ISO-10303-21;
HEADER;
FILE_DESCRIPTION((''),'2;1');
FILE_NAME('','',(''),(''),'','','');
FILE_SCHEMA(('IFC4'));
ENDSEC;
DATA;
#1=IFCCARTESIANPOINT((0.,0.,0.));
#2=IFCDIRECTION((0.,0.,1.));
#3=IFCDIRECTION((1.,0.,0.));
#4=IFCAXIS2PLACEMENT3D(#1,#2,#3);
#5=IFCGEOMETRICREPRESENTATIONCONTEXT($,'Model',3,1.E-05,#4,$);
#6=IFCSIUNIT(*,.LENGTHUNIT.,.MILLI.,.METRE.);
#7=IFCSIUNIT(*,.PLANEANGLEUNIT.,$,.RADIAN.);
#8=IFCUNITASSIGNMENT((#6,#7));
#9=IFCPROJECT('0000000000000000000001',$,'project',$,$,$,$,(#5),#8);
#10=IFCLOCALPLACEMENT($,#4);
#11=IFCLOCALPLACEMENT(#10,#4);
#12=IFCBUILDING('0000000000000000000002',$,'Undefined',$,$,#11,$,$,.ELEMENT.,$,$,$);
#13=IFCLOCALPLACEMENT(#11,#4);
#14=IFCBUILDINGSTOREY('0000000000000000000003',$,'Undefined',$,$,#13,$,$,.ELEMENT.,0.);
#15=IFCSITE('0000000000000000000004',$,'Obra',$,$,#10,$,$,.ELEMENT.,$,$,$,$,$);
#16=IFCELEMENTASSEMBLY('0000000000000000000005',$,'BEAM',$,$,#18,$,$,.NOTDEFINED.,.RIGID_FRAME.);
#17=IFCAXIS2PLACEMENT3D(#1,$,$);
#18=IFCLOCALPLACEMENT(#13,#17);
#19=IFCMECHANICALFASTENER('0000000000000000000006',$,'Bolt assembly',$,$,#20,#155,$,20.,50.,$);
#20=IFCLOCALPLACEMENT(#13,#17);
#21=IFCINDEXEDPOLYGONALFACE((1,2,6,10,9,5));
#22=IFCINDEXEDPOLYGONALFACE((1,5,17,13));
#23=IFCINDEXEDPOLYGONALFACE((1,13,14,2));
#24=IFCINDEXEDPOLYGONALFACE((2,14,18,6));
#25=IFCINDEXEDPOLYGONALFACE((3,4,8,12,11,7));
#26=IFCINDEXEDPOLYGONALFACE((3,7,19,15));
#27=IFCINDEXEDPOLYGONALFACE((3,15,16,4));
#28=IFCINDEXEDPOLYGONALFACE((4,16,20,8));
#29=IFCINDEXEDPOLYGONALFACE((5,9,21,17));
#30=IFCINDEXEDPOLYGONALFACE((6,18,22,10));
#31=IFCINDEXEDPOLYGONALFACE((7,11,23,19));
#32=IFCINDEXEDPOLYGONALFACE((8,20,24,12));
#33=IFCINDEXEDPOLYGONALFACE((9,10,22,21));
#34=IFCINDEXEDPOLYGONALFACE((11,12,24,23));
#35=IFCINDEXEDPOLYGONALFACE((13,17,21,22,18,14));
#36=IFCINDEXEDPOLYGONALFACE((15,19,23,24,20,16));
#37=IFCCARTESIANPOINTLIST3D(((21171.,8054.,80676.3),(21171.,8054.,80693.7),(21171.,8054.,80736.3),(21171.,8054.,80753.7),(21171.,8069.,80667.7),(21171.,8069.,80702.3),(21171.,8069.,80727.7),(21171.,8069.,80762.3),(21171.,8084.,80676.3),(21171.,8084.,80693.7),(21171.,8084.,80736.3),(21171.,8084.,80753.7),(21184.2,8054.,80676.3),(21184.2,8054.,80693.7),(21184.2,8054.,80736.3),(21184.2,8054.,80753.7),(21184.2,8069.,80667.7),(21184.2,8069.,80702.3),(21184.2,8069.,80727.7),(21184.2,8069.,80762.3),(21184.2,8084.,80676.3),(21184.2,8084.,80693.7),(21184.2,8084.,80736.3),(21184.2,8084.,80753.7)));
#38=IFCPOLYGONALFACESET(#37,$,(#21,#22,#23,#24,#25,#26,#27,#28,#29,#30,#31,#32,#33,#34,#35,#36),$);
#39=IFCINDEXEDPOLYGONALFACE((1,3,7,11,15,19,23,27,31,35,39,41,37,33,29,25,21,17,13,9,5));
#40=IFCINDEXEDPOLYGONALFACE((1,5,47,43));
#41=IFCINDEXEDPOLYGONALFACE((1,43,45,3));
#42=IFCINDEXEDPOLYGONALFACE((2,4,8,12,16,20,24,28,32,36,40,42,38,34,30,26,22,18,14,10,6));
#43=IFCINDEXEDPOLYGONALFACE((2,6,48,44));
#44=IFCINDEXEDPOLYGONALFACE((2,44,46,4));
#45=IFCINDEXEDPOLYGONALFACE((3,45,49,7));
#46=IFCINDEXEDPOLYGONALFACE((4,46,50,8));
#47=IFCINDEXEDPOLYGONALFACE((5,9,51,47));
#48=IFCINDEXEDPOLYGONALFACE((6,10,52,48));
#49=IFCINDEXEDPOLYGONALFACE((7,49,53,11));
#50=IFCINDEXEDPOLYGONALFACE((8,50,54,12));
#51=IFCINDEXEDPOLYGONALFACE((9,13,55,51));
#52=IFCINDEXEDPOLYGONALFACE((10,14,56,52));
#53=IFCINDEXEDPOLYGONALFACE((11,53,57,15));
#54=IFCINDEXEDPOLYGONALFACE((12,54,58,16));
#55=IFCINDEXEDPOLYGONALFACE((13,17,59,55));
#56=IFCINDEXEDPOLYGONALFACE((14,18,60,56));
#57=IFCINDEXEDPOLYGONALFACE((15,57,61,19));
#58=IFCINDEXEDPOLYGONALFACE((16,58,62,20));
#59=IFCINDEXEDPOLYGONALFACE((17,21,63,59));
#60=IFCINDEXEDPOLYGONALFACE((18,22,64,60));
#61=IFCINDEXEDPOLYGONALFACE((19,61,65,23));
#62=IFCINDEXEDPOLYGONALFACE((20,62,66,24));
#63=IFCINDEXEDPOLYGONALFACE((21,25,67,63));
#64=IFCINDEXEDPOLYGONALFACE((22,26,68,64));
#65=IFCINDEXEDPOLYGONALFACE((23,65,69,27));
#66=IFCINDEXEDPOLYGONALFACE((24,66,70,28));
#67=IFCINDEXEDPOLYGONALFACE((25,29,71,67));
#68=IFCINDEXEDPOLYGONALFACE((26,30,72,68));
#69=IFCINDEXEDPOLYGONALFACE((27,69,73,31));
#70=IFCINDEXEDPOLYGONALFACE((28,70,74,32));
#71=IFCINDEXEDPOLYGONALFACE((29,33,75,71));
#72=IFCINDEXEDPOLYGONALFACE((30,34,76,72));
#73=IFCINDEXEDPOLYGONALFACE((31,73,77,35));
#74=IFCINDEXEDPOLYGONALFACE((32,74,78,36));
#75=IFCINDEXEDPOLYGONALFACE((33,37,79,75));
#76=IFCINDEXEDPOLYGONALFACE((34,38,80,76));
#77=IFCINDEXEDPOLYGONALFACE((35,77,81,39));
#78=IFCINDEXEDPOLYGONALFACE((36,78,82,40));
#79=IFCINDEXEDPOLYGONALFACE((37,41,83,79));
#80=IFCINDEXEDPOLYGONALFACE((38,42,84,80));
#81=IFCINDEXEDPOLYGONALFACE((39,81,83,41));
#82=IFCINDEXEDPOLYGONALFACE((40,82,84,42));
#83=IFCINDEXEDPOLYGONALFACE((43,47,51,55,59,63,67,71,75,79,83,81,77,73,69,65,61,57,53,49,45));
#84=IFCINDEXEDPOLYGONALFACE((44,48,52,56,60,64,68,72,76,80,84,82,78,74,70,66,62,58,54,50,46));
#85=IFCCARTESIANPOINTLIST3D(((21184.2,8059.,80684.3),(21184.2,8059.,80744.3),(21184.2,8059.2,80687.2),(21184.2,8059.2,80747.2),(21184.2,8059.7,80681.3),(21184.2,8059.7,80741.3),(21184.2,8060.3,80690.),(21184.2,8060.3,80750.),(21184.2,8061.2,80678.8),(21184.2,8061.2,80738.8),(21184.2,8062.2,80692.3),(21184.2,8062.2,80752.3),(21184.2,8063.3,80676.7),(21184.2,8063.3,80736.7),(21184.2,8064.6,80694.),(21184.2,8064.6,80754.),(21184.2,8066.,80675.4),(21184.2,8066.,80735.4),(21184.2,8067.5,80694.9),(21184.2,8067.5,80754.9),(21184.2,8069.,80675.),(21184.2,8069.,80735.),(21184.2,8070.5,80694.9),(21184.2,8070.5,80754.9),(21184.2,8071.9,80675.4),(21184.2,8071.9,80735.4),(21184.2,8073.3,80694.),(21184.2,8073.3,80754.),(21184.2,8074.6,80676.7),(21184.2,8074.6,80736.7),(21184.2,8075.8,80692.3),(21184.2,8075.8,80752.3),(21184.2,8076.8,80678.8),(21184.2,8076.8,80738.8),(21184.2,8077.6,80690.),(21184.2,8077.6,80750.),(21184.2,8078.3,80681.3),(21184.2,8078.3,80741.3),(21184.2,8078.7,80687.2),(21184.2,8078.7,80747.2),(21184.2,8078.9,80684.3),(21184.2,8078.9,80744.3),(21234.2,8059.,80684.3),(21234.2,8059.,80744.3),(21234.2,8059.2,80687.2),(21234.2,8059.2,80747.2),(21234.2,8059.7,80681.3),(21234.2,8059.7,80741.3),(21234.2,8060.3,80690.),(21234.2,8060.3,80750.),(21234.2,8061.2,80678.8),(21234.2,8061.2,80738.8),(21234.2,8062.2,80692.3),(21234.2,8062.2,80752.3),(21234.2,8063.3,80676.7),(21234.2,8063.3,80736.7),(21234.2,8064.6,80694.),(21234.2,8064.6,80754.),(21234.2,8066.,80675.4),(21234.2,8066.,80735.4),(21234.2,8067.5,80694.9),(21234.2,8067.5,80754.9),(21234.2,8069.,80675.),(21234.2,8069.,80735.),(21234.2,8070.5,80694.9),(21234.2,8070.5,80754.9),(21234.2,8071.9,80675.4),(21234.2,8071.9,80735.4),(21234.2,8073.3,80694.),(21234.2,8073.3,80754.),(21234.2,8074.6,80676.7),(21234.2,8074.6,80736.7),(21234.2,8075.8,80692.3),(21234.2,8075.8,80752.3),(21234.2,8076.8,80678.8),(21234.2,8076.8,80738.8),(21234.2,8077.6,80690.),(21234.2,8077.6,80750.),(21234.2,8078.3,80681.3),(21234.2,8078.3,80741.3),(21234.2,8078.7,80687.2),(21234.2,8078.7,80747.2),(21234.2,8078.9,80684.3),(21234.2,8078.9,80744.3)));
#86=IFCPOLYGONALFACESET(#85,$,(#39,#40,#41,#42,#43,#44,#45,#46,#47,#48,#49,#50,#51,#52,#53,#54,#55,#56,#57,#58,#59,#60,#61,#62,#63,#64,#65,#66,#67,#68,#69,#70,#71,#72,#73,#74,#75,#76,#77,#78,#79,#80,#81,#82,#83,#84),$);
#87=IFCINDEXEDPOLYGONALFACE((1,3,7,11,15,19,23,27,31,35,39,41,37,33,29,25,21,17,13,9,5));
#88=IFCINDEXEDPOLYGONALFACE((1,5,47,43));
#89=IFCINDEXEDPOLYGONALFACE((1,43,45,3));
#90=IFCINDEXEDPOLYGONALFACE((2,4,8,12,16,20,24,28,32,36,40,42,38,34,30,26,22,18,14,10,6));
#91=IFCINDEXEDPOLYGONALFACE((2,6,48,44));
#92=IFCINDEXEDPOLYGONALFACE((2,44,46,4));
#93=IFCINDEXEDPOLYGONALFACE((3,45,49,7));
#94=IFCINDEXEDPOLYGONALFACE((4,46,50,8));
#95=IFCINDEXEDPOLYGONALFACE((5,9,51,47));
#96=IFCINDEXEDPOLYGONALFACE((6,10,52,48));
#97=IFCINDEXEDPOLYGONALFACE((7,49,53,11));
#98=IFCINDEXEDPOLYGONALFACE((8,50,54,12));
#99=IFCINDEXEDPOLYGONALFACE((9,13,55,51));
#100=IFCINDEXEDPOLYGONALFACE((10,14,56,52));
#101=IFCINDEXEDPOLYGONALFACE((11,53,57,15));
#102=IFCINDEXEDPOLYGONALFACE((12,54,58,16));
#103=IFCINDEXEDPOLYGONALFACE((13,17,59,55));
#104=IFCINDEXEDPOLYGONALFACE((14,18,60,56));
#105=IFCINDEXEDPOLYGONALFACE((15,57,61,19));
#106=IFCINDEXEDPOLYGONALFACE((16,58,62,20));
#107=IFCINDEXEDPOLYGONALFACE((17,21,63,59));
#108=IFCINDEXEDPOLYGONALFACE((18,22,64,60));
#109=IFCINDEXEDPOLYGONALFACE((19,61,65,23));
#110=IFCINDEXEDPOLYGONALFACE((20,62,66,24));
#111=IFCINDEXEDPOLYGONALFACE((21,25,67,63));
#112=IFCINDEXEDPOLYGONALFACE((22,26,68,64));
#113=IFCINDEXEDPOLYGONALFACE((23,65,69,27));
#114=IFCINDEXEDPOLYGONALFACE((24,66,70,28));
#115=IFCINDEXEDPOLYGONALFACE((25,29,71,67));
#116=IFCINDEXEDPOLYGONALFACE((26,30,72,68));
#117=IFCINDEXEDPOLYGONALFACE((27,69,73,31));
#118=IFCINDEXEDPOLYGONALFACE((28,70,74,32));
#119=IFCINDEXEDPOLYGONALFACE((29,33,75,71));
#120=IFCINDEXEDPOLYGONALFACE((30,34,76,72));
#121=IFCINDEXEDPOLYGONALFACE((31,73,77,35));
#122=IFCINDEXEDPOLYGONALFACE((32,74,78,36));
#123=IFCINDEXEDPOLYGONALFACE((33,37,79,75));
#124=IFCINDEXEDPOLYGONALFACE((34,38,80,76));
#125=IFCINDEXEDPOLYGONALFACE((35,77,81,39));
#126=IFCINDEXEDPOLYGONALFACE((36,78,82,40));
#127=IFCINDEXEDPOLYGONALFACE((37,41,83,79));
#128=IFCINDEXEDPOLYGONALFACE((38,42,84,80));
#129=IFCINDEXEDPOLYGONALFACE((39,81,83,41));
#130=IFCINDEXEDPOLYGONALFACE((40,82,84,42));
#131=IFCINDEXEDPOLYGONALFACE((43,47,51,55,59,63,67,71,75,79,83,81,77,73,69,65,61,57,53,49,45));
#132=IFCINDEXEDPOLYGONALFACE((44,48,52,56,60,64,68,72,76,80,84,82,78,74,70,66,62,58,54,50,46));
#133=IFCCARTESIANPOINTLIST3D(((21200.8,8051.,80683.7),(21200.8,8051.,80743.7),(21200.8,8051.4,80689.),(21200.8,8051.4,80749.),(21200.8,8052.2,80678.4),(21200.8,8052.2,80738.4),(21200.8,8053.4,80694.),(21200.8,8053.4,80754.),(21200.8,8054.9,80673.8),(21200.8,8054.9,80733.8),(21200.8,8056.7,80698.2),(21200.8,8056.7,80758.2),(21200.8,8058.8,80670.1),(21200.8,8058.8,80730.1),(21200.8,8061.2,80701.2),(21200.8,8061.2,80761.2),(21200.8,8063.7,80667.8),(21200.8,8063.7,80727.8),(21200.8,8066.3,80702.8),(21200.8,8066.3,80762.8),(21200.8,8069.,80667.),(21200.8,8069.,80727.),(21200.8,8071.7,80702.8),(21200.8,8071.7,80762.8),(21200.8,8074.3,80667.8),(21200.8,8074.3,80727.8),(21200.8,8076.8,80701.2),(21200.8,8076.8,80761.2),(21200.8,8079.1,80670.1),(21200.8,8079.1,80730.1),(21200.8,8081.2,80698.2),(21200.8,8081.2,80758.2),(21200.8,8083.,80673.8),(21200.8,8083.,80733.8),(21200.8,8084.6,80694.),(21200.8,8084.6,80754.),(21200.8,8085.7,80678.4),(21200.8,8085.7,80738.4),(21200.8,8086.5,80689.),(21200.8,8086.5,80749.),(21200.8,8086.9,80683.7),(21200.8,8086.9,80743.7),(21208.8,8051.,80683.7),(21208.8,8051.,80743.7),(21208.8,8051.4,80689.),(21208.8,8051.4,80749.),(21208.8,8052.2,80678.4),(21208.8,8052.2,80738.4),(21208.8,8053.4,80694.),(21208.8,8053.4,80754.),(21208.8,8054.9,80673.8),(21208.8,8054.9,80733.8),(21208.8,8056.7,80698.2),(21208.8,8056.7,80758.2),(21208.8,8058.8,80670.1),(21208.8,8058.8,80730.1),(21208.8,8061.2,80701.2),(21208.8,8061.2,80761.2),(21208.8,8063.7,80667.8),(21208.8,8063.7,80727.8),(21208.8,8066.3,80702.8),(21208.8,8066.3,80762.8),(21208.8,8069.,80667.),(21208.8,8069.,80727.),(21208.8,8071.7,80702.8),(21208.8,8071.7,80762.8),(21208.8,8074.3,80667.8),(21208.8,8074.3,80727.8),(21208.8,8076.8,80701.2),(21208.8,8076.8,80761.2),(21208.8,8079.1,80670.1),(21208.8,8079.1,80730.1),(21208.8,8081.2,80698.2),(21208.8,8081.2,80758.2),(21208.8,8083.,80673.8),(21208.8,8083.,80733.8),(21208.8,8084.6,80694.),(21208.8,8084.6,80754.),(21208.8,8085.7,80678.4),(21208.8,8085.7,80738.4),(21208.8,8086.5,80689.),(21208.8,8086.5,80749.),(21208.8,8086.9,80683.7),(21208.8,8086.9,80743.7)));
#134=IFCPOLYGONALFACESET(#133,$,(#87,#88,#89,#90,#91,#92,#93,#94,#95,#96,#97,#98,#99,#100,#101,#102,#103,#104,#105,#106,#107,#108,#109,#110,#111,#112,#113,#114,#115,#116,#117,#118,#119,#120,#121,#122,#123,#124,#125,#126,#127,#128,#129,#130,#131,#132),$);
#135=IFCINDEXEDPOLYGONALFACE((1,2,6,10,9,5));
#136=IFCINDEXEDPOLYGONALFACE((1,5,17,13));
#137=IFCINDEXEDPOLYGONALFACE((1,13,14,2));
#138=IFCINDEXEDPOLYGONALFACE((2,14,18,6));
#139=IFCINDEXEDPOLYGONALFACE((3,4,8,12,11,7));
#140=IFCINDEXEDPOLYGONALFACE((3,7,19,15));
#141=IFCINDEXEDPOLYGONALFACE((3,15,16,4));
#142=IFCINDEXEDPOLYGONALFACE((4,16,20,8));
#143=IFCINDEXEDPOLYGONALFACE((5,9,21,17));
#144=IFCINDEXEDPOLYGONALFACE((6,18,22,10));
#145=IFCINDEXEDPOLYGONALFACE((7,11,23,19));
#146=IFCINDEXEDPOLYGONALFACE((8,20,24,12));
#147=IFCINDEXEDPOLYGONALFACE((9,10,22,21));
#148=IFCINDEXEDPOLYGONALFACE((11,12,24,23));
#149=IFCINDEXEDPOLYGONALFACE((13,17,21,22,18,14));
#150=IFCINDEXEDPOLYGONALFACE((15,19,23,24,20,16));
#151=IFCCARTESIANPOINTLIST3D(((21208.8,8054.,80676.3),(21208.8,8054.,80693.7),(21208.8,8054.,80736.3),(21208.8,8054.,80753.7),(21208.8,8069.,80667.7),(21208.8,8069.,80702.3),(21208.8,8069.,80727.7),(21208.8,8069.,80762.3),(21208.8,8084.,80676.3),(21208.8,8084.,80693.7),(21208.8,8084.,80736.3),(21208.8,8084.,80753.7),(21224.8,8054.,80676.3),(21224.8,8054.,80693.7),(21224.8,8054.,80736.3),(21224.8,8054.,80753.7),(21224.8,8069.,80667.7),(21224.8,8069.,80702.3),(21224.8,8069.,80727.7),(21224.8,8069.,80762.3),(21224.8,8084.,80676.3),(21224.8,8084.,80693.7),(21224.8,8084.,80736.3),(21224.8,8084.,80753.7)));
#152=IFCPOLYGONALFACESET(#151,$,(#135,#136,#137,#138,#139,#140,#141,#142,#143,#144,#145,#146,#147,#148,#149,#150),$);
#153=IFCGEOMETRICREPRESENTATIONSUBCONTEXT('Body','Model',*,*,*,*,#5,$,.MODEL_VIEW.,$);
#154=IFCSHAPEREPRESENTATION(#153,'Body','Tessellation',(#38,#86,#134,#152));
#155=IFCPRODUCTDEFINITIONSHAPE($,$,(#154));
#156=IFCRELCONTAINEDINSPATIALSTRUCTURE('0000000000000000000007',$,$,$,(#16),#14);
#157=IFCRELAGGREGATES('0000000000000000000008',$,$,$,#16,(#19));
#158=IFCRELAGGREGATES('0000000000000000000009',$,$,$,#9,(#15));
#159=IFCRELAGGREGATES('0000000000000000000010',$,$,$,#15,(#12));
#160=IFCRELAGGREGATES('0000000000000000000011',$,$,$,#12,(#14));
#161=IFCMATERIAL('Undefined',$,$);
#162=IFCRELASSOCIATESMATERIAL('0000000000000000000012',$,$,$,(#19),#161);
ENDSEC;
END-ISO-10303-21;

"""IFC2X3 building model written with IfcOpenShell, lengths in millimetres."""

from ifc_helpers import new_model, si_unit, frame, origin_with_axes, origin_2d_with_axis, place, context, subcontext, project, spatial, polyline, circle, outline, extrude, source, transform, mapped, material, element, aggregate, save


model = new_model("IFC2X3")

# Units and contexts
model_context = context("Model", 3, precision=1e-05, world=origin_with_axes())
body_context = subcontext(model_context, "Body", "Model", "MODEL_VIEW")
ifc_project = project(units=[si_unit("LENGTHUNIT", "METRE", prefix="MILLI"), si_unit("PLANEANGLEUNIT", "RADIAN")], contexts=[model_context])

# Site, building, storey
site_placement = place(None, origin_with_axes())
site = spatial("IfcSite", under=ifc_project, at=site_placement, Name="Obra", CompositionType="ELEMENT")
building_placement = place(site_placement, origin_with_axes())
building = spatial("IfcBuilding", under=site, at=building_placement, Name="Undefined", CompositionType="ELEMENT")
storey_placement = place(building_placement, origin_with_axes())
storey = spatial("IfcBuildingStorey", under=building, at=storey_placement, Name="Undefined", CompositionType="ELEMENT", Elevation=0.0)

# Element assembly, mechanical fastener
ifc_material_1 = material(Name="Undefined")
shared_shape_1 = source(origin_with_axes(), body_context, "Body", "SweptSolid", [
    extrude(outline(polyline([(17.3, 0.0), (8.7, 15.0), (-8.7, 15.0), (-17.3, 0.0), (-8.7, -15.0), (8.7, -15.0), (17.3, 0.0)])), frame((0.0, -26.5, 0.0), z_axis=(0.0, 1.0, 0.0), x_axis=(1.0, 0.0, 0.0)), (0.0, 0.0, 1.0), 13.2),
    extrude(circle(Radius=10.0, at=origin_2d_with_axis()), frame((0.0, -13.3, 0.0), z_axis=(0.0, 1.0, 0.0), x_axis=(1.0, 0.0, 0.0)), (0.0, 0.0, 1.0), 50.0),
    extrude(circle(Radius=18.0, at=origin_2d_with_axis()), frame((0.0, 3.3, 0.0), z_axis=(0.0, 1.0, 0.0), x_axis=(1.0, 0.0, 0.0)), (0.0, 0.0, 1.0), 8.0),
    extrude(outline(polyline([(17.3, 0.0), (8.7, 15.0), (-8.7, 15.0), (-17.3, 0.0), (-8.7, -15.0), (8.7, -15.0), (17.3, 0.0)])), frame((0.0, 11.3, 0.0), z_axis=(0.0, 1.0, 0.0), x_axis=(1.0, 0.0, 0.0)), (0.0, 0.0, 1.0), 16.0),
])
assembly_1_placement = place(storey_placement, origin_with_axes())
assembly_1 = element("IfcElementAssembly", 1, at=assembly_1_placement, inside=storey, Name="BEAM", AssemblyPlace="NOTDEFINED", PredefinedType="RIGID_FRAME")
mechanical_fastener_1_placement = place(assembly_1_placement, frame((21197.5, 8109.0, 80850.0), z_axis=(0.0, -1.0, 0.0), x_axis=(0.0, 0.0, -1.0)))
mechanical_fastener_1 = element("IfcMechanicalFastener", 2, at=mechanical_fastener_1_placement, material=ifc_material_1, Name="Bolt assembly", NominalDiameter=20.0, NominalLength=50.0, context=body_context, shape_type="MappedRepresentation", body=[
    mapped(shared_shape_1, transform((105.0, 0.0, 40.0))),
    mapped(shared_shape_1, transform((165.0, 0.0, 40.0))),
])
aggregate(assembly_1, [mechanical_fastener_1])

save(model, "model.ifc")
